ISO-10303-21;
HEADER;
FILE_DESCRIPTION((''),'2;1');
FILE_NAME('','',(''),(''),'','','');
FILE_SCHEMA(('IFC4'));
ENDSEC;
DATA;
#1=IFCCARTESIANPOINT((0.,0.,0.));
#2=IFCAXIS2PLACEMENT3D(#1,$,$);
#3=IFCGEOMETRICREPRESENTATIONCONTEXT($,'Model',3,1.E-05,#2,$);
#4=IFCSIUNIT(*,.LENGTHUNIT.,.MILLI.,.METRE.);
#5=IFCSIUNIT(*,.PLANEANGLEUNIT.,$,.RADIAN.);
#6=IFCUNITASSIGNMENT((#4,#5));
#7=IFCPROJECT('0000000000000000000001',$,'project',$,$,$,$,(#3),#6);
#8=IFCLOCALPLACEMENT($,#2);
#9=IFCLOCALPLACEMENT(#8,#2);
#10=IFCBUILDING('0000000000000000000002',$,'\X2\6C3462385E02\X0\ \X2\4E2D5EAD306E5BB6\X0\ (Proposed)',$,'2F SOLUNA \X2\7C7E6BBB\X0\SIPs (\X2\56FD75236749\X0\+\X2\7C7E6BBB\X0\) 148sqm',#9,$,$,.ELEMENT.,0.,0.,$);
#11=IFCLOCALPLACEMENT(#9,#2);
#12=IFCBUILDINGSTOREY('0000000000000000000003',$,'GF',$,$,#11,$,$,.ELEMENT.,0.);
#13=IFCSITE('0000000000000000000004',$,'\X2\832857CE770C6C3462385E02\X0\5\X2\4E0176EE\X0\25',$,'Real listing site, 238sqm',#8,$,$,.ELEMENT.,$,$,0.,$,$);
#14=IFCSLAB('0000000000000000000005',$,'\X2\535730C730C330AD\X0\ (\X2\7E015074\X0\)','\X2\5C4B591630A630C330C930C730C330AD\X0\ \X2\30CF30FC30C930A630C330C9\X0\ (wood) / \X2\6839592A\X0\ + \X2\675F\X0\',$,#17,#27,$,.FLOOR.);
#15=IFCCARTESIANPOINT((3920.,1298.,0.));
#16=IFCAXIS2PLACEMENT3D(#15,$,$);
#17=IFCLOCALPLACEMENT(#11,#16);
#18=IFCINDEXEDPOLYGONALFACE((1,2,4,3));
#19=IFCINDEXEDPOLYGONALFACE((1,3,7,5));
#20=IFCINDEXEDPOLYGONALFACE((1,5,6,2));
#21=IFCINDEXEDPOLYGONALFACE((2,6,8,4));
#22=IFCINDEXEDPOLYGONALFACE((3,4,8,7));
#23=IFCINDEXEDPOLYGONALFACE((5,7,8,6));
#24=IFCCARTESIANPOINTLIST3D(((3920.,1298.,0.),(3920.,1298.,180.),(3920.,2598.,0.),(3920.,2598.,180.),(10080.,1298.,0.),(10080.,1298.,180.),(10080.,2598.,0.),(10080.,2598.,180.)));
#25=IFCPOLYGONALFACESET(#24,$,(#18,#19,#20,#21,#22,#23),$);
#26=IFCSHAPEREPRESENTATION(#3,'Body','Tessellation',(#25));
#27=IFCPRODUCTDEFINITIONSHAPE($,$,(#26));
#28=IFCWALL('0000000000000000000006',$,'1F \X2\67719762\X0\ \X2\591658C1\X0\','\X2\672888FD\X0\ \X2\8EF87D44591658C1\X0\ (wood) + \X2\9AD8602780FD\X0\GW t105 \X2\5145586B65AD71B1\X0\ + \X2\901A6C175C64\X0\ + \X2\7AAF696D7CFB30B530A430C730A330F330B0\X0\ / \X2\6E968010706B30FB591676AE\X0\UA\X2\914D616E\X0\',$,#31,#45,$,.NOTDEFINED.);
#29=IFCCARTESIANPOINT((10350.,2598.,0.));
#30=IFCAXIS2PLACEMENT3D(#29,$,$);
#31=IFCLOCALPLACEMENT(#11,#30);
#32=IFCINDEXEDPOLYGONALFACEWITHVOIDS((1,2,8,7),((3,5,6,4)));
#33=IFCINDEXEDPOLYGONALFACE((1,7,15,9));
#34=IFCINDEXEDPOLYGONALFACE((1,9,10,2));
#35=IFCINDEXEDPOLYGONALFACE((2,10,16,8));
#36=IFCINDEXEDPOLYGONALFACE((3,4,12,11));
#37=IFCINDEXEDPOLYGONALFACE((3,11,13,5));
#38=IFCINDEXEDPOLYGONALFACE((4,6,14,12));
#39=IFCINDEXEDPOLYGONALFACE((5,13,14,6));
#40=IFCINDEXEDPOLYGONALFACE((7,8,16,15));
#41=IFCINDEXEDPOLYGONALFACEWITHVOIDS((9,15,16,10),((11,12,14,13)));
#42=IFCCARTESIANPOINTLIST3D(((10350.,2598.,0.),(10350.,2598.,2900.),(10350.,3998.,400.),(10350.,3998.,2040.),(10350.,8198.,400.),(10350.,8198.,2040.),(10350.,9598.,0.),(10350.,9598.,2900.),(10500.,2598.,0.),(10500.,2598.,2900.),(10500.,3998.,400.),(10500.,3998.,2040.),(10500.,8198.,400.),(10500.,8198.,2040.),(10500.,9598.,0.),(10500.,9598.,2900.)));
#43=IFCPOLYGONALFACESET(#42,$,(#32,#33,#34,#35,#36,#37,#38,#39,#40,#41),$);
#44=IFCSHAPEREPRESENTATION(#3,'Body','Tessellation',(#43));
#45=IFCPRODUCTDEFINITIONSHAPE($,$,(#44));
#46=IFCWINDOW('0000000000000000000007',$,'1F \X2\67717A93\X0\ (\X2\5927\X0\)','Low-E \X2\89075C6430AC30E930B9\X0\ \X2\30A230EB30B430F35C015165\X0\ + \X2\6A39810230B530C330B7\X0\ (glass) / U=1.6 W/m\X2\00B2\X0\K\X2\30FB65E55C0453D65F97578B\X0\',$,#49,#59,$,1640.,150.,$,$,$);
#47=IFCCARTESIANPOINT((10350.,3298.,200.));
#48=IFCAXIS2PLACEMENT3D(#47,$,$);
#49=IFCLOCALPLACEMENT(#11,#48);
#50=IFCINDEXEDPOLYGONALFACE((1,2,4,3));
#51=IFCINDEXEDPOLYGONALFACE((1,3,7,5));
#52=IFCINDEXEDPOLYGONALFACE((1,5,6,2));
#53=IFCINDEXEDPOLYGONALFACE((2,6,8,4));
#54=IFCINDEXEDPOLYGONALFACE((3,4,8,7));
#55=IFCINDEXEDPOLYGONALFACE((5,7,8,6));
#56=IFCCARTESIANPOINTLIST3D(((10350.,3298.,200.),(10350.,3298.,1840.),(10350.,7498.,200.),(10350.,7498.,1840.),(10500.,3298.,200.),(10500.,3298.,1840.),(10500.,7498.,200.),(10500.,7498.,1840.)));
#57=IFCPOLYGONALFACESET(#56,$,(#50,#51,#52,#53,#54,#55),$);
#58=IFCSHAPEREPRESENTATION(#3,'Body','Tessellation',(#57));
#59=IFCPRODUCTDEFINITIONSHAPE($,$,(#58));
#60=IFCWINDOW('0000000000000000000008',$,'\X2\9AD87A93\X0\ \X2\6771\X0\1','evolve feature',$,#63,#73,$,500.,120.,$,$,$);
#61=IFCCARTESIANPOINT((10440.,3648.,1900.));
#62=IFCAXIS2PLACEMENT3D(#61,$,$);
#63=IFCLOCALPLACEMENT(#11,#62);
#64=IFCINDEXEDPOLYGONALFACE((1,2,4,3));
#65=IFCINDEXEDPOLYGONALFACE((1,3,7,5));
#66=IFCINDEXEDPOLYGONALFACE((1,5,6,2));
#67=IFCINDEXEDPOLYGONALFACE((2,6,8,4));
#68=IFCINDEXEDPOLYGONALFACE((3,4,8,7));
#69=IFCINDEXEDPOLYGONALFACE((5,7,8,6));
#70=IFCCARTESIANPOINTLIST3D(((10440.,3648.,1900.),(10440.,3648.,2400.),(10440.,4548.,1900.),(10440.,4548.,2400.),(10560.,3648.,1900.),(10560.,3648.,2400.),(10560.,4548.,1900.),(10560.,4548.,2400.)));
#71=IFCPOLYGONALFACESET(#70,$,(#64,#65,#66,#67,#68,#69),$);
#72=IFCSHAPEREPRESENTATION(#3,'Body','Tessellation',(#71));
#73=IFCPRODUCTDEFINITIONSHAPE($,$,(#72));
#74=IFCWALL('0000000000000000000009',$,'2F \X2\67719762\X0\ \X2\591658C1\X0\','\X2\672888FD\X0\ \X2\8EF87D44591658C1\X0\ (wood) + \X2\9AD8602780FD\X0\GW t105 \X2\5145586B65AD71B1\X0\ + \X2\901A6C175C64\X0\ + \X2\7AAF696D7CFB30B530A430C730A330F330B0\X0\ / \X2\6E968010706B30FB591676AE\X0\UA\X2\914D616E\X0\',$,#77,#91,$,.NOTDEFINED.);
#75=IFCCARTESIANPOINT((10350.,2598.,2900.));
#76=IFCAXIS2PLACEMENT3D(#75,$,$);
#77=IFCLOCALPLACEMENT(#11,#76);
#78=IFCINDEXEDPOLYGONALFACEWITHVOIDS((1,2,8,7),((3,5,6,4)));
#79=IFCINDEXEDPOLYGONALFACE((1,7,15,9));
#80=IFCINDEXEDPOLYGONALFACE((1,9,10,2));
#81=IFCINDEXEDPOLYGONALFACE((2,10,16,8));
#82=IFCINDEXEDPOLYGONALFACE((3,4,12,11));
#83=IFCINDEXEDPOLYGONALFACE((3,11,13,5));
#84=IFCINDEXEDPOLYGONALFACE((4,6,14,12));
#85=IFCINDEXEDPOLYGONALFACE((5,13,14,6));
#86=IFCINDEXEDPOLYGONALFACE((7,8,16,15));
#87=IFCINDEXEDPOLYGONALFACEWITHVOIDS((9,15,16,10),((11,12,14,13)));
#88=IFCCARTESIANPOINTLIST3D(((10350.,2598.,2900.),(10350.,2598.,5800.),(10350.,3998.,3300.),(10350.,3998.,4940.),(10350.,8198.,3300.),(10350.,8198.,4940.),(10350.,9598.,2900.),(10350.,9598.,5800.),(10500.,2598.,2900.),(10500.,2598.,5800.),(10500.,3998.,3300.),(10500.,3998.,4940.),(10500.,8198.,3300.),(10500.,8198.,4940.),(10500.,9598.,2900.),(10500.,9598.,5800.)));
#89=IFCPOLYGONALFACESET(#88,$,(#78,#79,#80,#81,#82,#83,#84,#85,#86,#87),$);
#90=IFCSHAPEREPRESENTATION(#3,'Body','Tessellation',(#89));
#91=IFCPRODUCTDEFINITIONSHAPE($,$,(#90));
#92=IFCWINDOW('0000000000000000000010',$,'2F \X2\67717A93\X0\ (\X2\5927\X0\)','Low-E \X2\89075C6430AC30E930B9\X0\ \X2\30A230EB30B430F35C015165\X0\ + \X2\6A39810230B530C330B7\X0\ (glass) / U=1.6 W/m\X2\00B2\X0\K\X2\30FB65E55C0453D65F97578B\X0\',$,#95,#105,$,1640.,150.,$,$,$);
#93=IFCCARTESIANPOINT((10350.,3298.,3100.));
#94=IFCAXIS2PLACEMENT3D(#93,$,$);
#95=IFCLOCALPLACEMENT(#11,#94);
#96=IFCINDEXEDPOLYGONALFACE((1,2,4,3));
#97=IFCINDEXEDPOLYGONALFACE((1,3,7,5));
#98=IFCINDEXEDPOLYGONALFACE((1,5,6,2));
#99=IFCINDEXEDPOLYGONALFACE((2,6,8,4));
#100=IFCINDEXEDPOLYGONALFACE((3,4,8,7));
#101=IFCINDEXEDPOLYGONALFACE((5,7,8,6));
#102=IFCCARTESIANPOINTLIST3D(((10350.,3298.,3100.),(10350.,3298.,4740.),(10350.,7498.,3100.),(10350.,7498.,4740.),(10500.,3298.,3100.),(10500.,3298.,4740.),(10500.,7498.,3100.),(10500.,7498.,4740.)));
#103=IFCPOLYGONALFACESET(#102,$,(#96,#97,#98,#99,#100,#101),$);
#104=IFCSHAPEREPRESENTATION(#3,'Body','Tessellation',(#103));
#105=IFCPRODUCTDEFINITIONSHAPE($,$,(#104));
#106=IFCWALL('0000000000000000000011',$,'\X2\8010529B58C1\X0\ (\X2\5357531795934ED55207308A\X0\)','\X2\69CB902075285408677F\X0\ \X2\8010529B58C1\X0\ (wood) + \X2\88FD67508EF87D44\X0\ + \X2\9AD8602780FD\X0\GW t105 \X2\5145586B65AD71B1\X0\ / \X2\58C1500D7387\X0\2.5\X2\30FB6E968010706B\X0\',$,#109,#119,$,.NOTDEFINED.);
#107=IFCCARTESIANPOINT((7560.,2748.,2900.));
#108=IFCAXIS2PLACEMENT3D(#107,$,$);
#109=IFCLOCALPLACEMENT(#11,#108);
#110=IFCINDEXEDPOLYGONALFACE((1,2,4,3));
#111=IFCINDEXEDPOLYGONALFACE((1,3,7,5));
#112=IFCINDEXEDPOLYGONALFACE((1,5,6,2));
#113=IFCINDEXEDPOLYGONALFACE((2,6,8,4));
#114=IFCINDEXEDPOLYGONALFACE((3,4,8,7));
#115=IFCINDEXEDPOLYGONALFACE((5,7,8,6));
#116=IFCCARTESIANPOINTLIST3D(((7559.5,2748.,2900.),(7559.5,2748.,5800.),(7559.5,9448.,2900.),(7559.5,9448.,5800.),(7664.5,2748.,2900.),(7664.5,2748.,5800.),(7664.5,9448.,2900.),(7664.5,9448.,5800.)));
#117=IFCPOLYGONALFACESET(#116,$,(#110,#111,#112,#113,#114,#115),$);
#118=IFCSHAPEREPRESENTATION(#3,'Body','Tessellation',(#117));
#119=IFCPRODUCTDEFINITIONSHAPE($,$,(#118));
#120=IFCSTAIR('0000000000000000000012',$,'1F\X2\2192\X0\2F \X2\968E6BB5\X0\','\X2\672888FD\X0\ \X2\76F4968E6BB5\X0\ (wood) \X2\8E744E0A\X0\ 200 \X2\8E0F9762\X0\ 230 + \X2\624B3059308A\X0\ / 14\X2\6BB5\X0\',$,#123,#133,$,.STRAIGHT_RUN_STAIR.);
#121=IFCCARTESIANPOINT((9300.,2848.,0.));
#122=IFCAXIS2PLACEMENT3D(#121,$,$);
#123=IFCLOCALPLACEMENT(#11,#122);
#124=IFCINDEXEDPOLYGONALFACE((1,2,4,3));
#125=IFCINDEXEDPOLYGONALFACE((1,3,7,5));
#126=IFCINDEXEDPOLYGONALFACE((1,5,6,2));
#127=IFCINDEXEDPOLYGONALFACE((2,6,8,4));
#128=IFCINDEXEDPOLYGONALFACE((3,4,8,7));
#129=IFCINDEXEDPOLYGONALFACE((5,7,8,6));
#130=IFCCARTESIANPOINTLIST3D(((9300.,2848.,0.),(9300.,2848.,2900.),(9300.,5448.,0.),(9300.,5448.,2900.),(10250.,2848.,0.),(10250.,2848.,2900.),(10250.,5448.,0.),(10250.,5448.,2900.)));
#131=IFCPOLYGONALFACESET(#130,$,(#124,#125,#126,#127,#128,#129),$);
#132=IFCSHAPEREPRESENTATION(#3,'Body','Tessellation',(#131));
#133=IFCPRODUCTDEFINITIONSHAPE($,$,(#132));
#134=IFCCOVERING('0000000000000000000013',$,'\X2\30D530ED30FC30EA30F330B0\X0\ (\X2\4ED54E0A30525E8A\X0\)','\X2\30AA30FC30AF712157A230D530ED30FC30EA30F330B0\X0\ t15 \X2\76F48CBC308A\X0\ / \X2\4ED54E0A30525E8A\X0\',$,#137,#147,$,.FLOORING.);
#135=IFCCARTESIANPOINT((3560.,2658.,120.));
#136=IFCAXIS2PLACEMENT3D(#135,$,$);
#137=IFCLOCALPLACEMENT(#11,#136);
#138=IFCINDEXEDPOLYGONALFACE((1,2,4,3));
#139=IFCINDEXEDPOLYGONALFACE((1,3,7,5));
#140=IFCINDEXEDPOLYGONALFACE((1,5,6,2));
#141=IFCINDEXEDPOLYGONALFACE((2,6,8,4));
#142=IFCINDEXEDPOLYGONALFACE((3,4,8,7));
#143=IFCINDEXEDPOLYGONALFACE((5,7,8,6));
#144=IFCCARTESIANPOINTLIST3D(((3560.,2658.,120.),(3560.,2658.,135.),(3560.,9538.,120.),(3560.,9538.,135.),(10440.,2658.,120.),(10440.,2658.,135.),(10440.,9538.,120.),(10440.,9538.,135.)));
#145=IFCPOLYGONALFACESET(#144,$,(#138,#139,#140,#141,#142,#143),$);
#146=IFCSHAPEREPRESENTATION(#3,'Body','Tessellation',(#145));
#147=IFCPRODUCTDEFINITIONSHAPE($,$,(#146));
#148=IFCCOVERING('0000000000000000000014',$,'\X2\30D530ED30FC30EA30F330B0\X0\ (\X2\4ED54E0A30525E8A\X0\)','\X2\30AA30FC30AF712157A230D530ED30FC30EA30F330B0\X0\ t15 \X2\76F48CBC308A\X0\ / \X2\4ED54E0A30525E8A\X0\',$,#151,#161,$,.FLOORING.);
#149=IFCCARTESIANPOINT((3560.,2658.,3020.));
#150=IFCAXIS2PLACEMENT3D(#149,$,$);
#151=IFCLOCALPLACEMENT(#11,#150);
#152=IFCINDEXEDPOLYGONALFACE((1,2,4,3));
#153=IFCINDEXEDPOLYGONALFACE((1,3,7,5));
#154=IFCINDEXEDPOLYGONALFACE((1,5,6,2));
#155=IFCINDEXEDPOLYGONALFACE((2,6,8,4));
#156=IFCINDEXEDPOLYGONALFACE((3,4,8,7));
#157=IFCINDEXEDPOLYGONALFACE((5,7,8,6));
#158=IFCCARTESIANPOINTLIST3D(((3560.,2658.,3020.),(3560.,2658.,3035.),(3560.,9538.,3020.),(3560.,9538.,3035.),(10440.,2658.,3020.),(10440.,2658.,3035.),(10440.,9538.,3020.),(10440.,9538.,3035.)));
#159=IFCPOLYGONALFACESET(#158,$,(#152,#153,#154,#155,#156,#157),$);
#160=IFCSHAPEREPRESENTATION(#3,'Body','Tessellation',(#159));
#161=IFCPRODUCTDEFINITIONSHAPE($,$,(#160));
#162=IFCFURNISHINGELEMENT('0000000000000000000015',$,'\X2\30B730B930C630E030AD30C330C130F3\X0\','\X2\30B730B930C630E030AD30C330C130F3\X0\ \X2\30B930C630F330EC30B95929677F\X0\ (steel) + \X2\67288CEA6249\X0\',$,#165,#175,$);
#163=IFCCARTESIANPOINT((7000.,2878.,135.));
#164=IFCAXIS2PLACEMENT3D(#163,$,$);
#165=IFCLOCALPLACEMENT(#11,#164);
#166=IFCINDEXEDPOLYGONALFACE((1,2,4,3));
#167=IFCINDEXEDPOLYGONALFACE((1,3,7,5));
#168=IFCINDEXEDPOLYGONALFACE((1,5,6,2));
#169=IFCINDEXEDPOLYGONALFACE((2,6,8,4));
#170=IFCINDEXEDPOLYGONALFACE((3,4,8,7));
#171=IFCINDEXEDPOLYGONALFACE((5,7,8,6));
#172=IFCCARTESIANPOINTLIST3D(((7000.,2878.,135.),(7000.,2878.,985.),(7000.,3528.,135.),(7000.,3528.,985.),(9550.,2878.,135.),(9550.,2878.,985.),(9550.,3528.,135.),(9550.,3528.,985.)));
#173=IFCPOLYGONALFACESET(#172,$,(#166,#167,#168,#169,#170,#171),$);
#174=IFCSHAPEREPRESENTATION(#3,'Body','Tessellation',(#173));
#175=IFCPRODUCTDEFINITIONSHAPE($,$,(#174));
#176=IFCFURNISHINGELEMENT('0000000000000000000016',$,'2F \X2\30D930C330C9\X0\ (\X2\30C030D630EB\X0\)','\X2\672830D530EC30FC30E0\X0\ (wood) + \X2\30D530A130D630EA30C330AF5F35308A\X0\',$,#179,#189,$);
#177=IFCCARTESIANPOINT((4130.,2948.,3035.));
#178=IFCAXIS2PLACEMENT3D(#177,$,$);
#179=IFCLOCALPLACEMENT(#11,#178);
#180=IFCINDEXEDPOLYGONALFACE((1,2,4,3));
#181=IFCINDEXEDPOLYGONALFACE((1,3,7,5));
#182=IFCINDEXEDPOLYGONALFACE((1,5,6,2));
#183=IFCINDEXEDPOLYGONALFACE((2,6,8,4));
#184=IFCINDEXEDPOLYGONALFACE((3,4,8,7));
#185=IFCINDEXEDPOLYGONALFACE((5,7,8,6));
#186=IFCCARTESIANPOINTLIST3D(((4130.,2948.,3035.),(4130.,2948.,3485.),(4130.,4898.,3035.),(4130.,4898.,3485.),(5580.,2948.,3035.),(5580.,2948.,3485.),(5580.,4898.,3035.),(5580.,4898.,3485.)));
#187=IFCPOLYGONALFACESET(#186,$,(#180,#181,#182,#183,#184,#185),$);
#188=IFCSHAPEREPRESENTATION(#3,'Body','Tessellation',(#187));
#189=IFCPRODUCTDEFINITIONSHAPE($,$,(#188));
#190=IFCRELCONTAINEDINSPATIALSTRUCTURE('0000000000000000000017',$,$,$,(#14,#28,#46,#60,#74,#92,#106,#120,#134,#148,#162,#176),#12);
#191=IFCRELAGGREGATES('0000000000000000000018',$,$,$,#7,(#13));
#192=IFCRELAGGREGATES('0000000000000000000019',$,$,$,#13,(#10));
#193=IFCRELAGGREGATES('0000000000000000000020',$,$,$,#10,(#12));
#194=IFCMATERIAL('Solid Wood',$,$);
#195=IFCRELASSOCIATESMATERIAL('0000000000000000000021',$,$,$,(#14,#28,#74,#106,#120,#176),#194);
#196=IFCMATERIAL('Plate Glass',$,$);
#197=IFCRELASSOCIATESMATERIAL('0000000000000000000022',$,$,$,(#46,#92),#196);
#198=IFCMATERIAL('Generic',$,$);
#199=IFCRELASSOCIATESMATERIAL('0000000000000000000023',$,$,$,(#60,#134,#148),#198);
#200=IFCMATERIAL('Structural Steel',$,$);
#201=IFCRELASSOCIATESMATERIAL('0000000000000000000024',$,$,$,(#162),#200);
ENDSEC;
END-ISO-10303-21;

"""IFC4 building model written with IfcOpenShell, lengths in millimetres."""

from ifc_helpers import new_model, si_unit, frame, frame_2d, origin, place, context, project, spatial, rectangle, extrude, material, element, fill, save


model = new_model("IFC4")

# Units and contexts
model_context = context("Model", 3, precision=1e-05, world=origin())
ifc_project = project(units=[si_unit("LENGTHUNIT", "METRE", prefix="MILLI"), si_unit("PLANEANGLEUNIT", "RADIAN")], contexts=[model_context])

# Site, building, storey
site_placement = place(None, origin())
site = spatial("IfcSite", under=ifc_project, at=site_placement, Name="茨城県水戸市5丁目25", ObjectType="Real listing site, 238sqm", CompositionType="ELEMENT", RefElevation=0.0)
building_placement = place(site_placement, origin())
building = spatial("IfcBuilding", under=site, at=building_placement, Name="水戸市 中庭の家 (Proposed)", ObjectType="2F SOLUNA 籾殻SIPs (国産杉+籾殻) 148sqm", CompositionType="ELEMENT", ElevationOfRefHeight=0.0, ElevationOfTerrain=0.0)
storey_placement = place(building_placement, origin())
storey = spatial("IfcBuildingStorey", under=building, at=storey_placement, Name="GF", CompositionType="ELEMENT", Elevation=0.0)

# Slab
ifc_material_1 = material(Name="Solid Wood")
slab_placement = place(storey_placement, frame((3920.0, 1298.0, 0.0)))
element("IfcSlab", 1, at=slab_placement, inside=storey, material=ifc_material_1, Name="南デッキ (縁側)", Description="屋外ウッドデッキ ハードウッド (wood) / 根太 + 束", PredefinedType="FLOOR", context=model_context, shape_type="SweptSolid", body=[
    extrude(rectangle(XDim=6160.0, YDim=1300.0, at=frame_2d((3080.0, 650.0))), frame((3920.0, 1298.0, 0.0)), (0.0, 0.0, 1.0), 180.0),
])

# Wall, openings, windows
wall_1_placement = place(storey_placement, frame((10350.0, 2598.0, 0.0)))
wall_1 = element("IfcWall", 2, at=wall_1_placement, inside=storey, material=ifc_material_1, Name="1F 東面 外壁", Description="木製 軸組外壁 (wood) + 高性能GW t105 充填断熱 + 通気層 + 窯業系サイディング / 準耐火・外皮UA配慮", PredefinedType="NOTDEFINED", context=model_context, shape_type="SweptSolid", body=[
    extrude(rectangle(XDim=150.0, YDim=7000.0, at=frame_2d((75.0, 3500.0))), frame((10350.0, 2598.0, 0.0)), (0.0, 0.0, 1.0), 2900.0),
])
opening_1_placement = place(storey_placement, frame((10350.0, 3298.0, 200.0)))
opening_1 = element("IfcOpeningElement", 3, at=opening_1_placement, cuts=wall_1, PredefinedType="NOTDEFINED", context=model_context, shape_type="SweptSolid", body=[
    extrude(rectangle(XDim=150.0, YDim=4200.0, at=frame_2d((75.0, 2100.0))), frame((10350.0, 3298.0, 200.0)), (0.0, 0.0, 1.0), 1640.0),
])
opening_2_placement = place(storey_placement, frame((10440.0, 3648.0, 1900.0)))
opening_2 = element("IfcOpeningElement", 4, at=opening_2_placement, cuts=wall_1, PredefinedType="NOTDEFINED", context=model_context, shape_type="SweptSolid", body=[
    extrude(rectangle(XDim=120.0, YDim=900.0, at=frame_2d((60.0, 450.0))), frame((10440.0, 3648.0, 1900.0)), (0.0, 0.0, 1.0), 500.0),
])
ifc_material_2 = material(Name="Plate Glass")
window_1_placement = place(storey_placement, frame((10350.0, 3298.0, 200.0)))
window_1 = element("IfcWindow", 5, at=window_1_placement, inside=storey, material=ifc_material_2, Name="1F 東窓 (大)", Description="Low-E 複層ガラス アルゴン封入 + 樹脂サッシ (glass) / U=1.6 W/m²K・日射取得型", OverallHeight=1640.0, OverallWidth=150.0, context=model_context, shape_type="SweptSolid", body=[
    extrude(rectangle(XDim=150.0, YDim=4200.0, at=frame_2d((75.0, 2100.0))), frame((10350.0, 3298.0, 200.0)), (0.0, 0.0, 1.0), 1640.0),
])
fill(opening_1, window_1)
ifc_material_3 = material(Name="Generic")
window_2_placement = place(storey_placement, frame((10440.0, 3648.0, 1900.0)))
window_2 = element("IfcWindow", 6, at=window_2_placement, inside=storey, material=ifc_material_3, Name="高窓 東1", Description="evolve feature", OverallHeight=500.0, OverallWidth=120.0, context=model_context, shape_type="SweptSolid", body=[
    extrude(rectangle(XDim=120.0, YDim=900.0, at=frame_2d((60.0, 450.0))), frame((10440.0, 3648.0, 1900.0)), (0.0, 0.0, 1.0), 500.0),
])
fill(opening_2, window_2)

# Wall, opening, window
wall_2_placement = place(storey_placement, frame((10350.0, 2598.0, 2900.0)))
wall_2 = element("IfcWall", 7, at=wall_2_placement, inside=storey, material=ifc_material_1, Name="2F 東面 外壁", Description="木製 軸組外壁 (wood) + 高性能GW t105 充填断熱 + 通気層 + 窯業系サイディング / 準耐火・外皮UA配慮", PredefinedType="NOTDEFINED", context=model_context, shape_type="SweptSolid", body=[
    extrude(rectangle(XDim=150.0, YDim=7000.0, at=frame_2d((75.0, 3500.0))), frame((10350.0, 2598.0, 2900.0)), (0.0, 0.0, 1.0), 2900.0),
])
opening_3_placement = place(storey_placement, frame((10350.0, 3298.0, 3100.0)))
opening_3 = element("IfcOpeningElement", 8, at=opening_3_placement, cuts=wall_2, PredefinedType="NOTDEFINED", context=model_context, shape_type="SweptSolid", body=[
    extrude(rectangle(XDim=150.0, YDim=4200.0, at=frame_2d((75.0, 2100.0))), frame((10350.0, 3298.0, 3100.0)), (0.0, 0.0, 1.0), 1640.0),
])
window_3_placement = place(storey_placement, frame((10350.0, 3298.0, 3100.0)))
window_3 = element("IfcWindow", 9, at=window_3_placement, inside=storey, material=ifc_material_2, Name="2F 東窓 (大)", Description="Low-E 複層ガラス アルゴン封入 + 樹脂サッシ (glass) / U=1.6 W/m²K・日射取得型", OverallHeight=1640.0, OverallWidth=150.0, context=model_context, shape_type="SweptSolid", body=[
    extrude(rectangle(XDim=150.0, YDim=4200.0, at=frame_2d((75.0, 2100.0))), frame((10350.0, 3298.0, 3100.0)), (0.0, 0.0, 1.0), 1640.0),
])
fill(opening_3, window_3)

# Wall
wall_3_placement = place(storey_placement, frame((7560.0, 2748.0, 2900.0)))
element("IfcWall", 10, at=wall_3_placement, inside=storey, material=ifc_material_1, Name="耐力壁 (南北間仕切り)", Description="構造用合板 耐力壁 (wood) + 製材軸組 + 高性能GW t105 充填断熱 / 壁倍率2.5・準耐火", PredefinedType="NOTDEFINED", context=model_context, shape_type="SweptSolid", body=[
    extrude(rectangle(XDim=105.0, YDim=6700.0, at=frame_2d((52.0, 3350.0))), frame((7560.0, 2748.0, 2900.0)), (0.0, 0.0, 1.0), 2900.0),
])

# Stair
stair_placement = place(storey_placement, frame((9300.0, 2848.0, 0.0)))
element("IfcStair", 11, at=stair_placement, inside=storey, material=ifc_material_1, Name="1F→2F 階段", Description="木製 直階段 (wood) 蹴上 200 踏面 230 + 手すり / 14段", PredefinedType="STRAIGHT_RUN_STAIR", context=model_context, shape_type="SweptSolid", body=[
    extrude(rectangle(XDim=950.0, YDim=2600.0, at=frame_2d((475.0, 1300.0))), frame((9300.0, 2848.0, 0.0)), (0.0, 0.0, 1.0), 2900.0),
])

# Coverings
covering_1_placement = place(storey_placement, frame((3560.0, 2658.0, 120.0)))
element("IfcCovering", 12, at=covering_1_placement, inside=storey, material=ifc_material_3, Name="フローリング (仕上げ床)", Description="オーク無垢フローリング t15 直貼り / 仕上げ床", PredefinedType="FLOORING", context=model_context, shape_type="SweptSolid", body=[
    extrude(rectangle(XDim=6880.0, YDim=6880.0, at=frame_2d((3440.0, 3440.0))), frame((3560.0, 2658.0, 120.0)), (0.0, 0.0, 1.0), 15.0),
])
covering_2_placement = place(storey_placement, frame((3560.0, 2658.0, 3020.0)))
element("IfcCovering", 13, at=covering_2_placement, inside=storey, material=ifc_material_3, Name="フローリング (仕上げ床)", Description="オーク無垢フローリング t15 直貼り / 仕上げ床", PredefinedType="FLOORING", context=model_context, shape_type="SweptSolid", body=[
    extrude(rectangle(XDim=6880.0, YDim=6880.0, at=frame_2d((3440.0, 3440.0))), frame((3560.0, 2658.0, 3020.0)), (0.0, 0.0, 1.0), 15.0),
])

# Furnishing elements
ifc_material_4 = material(Name="Structural Steel")
furnishing_1_placement = place(storey_placement, frame((7000.0, 2878.0, 135.0)))
element("IfcFurnishingElement", 14, at=furnishing_1_placement, inside=storey, material=ifc_material_4, Name="システムキッチン", Description="システムキッチン ステンレス天板 (steel) + 木質扉", context=model_context, shape_type="SweptSolid", body=[
    extrude(rectangle(XDim=2550.0, YDim=650.0, at=frame_2d((1275.0, 325.0))), frame((7000.0, 2878.0, 135.0)), (0.0, 0.0, 1.0), 850.0),
])
furnishing_2_placement = place(storey_placement, frame((4130.0, 2948.0, 3035.0)))
element("IfcFurnishingElement", 15, at=furnishing_2_placement, inside=storey, material=ifc_material_1, Name="2F ベッド (ダブル)", Description="木フレーム (wood) + ファブリック張り", context=model_context, shape_type="SweptSolid", body=[
    extrude(rectangle(XDim=1450.0, YDim=1950.0, at=frame_2d((725.0, 975.0))), frame((4130.0, 2948.0, 3035.0)), (0.0, 0.0, 1.0), 450.0),
])

save(model, "model.ifc")
